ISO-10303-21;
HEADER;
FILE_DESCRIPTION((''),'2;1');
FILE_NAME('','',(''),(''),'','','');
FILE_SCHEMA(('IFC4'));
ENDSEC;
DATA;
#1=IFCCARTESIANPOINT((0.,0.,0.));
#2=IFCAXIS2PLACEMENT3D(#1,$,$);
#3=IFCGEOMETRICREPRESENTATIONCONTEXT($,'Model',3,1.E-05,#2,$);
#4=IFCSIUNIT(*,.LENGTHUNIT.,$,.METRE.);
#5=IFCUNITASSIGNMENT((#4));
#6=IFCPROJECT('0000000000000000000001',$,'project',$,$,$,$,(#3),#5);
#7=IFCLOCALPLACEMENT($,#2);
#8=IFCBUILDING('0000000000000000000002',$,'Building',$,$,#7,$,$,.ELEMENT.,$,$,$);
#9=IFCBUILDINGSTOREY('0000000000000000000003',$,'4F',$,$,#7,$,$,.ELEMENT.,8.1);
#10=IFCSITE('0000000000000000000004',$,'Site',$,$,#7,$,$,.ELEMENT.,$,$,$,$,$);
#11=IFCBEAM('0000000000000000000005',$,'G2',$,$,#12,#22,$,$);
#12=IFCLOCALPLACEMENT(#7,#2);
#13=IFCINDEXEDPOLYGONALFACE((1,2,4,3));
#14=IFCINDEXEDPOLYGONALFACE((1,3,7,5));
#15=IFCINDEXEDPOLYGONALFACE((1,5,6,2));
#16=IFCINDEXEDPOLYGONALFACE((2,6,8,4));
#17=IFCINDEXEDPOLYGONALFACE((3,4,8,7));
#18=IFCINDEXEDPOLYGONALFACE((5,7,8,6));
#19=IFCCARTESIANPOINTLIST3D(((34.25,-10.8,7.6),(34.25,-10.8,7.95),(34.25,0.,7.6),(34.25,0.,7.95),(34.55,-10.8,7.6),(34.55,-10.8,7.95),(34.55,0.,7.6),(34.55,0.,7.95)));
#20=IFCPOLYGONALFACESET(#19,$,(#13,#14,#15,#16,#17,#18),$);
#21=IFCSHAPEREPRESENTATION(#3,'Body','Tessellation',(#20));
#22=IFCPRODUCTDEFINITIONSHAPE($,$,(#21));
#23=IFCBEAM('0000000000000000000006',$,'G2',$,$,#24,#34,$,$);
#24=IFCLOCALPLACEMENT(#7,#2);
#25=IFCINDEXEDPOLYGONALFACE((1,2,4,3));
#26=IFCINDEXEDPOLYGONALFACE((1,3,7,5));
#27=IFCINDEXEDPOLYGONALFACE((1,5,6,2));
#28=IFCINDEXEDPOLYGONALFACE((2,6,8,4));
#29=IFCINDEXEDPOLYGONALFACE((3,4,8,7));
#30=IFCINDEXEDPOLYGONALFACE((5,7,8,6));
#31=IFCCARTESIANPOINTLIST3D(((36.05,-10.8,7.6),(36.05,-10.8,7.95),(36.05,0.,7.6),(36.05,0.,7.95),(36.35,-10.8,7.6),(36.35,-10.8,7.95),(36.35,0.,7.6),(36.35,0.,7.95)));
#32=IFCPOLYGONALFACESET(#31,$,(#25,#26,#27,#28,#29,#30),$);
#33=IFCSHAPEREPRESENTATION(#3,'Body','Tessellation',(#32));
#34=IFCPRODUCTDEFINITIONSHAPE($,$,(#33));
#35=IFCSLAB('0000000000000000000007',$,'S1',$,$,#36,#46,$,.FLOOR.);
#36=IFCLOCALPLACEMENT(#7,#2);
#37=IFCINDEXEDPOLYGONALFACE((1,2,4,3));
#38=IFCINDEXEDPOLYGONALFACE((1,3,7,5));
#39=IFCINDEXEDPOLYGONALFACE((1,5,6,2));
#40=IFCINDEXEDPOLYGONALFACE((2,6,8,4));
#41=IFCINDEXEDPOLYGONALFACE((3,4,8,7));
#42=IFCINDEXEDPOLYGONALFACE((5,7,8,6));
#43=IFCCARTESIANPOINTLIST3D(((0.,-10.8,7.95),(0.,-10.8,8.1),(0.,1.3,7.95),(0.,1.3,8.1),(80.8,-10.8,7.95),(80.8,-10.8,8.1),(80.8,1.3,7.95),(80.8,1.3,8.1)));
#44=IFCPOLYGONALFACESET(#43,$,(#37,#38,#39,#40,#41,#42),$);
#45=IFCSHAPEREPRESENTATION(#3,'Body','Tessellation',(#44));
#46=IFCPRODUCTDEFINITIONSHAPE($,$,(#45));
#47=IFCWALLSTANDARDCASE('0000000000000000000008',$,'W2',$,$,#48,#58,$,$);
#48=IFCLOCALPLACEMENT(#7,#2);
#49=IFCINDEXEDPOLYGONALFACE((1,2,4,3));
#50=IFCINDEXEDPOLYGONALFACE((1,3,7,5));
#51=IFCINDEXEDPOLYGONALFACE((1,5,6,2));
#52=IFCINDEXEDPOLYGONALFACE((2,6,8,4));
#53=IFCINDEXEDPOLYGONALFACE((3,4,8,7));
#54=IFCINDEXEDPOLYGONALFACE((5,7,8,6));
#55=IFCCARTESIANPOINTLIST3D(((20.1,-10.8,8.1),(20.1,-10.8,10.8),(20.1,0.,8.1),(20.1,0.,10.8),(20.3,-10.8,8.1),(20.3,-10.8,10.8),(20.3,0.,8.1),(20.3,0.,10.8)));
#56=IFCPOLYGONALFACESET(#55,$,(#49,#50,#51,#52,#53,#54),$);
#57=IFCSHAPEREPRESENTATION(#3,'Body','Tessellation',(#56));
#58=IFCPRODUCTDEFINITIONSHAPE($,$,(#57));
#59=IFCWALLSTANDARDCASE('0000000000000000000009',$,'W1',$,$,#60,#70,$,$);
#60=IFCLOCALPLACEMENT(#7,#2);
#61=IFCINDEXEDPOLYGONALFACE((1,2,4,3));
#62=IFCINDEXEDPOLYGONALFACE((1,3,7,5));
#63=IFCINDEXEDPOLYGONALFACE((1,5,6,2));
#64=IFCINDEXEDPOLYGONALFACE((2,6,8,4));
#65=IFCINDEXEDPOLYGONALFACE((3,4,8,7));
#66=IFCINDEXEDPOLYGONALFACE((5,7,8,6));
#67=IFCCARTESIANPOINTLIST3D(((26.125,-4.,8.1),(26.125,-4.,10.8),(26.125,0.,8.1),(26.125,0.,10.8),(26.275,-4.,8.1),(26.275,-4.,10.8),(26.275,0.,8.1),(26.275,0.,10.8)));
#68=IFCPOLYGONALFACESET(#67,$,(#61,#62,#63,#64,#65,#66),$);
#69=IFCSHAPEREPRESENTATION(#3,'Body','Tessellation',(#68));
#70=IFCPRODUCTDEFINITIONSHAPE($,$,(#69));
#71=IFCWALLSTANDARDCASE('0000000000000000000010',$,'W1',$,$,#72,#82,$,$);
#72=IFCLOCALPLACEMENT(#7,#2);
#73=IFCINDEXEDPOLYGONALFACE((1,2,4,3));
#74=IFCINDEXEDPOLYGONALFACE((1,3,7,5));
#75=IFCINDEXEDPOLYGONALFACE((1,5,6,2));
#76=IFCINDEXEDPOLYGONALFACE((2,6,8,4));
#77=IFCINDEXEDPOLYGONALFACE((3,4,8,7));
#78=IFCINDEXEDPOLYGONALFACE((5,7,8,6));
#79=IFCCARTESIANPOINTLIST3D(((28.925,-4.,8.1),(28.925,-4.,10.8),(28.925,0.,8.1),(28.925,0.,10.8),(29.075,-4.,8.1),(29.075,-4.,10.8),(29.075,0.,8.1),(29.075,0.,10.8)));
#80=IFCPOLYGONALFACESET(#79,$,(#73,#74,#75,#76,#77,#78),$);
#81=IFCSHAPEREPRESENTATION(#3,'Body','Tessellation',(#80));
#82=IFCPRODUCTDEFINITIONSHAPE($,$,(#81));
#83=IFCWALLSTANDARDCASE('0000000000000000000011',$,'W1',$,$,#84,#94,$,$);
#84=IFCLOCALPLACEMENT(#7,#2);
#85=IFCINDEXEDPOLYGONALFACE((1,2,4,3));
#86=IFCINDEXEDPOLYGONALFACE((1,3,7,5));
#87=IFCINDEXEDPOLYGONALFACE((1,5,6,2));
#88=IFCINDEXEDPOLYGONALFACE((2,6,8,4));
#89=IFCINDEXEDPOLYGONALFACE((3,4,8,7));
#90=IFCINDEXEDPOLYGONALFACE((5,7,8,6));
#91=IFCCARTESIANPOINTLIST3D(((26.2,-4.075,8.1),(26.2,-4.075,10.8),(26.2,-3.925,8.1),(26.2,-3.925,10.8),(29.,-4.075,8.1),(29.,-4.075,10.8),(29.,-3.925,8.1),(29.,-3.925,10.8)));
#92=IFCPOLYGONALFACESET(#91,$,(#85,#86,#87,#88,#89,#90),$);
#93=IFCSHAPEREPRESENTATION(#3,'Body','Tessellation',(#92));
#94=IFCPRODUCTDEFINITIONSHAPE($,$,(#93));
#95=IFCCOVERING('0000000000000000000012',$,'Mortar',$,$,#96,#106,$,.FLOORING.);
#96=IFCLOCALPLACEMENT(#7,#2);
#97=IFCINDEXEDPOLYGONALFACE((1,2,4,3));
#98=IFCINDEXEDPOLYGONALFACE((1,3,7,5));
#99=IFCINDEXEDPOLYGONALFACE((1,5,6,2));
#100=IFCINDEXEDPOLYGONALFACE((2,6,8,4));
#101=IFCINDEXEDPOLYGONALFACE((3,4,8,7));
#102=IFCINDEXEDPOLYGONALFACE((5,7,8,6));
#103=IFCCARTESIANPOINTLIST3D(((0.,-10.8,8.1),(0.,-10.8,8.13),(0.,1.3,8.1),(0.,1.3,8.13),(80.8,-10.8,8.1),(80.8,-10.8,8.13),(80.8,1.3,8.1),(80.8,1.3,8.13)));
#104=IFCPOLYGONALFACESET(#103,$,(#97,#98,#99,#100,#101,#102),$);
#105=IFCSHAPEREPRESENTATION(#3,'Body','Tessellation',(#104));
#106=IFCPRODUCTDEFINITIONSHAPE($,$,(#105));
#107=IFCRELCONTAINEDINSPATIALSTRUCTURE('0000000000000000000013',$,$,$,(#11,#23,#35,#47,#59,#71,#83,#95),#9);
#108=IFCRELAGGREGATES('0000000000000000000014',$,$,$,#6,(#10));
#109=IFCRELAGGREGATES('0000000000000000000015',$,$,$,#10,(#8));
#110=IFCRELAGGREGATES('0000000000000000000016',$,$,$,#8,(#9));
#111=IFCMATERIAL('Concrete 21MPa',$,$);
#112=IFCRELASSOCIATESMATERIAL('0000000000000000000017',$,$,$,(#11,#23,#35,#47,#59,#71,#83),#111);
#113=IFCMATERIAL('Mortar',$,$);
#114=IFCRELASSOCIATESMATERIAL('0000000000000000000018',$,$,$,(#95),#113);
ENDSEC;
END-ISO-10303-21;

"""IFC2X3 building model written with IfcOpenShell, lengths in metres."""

from ifc_helpers import new_model, si_unit, frame, origin, origin_2d, place, context, project, spatial, rectangle, extrude, material, element, save


model = new_model("IFC2X3")

# Units and contexts
model_context = context("Model", 3, precision=1e-05, world=origin())
ifc_project = project(units=[si_unit("LENGTHUNIT", "METRE")], contexts=[model_context])

# Site, building, storey
placement = place(None, origin())
site = spatial("IfcSite", under=ifc_project, at=placement, Name="Site", CompositionType="ELEMENT")
building = spatial("IfcBuilding", under=site, at=placement, Name="Building", CompositionType="ELEMENT")
storey = spatial("IfcBuildingStorey", under=building, at=placement, Name="4F", CompositionType="ELEMENT", Elevation=8.1)

# Shared definitions
ifc_material_1 = material(Name="Concrete 21MPa")

# Beams
for number, where, name in (
    (1, (34.4, -5.4, 7.6), "G2"),
    (2, (36.2, -5.4, 7.6), "G2"),
):
    element("IfcBeam", number, at=place(None, frame(where)), inside=storey, material=ifc_material_1, Name=name, context=model_context, shape_type="SweptSolid", body=[
        extrude(rectangle(XDim=0.3, YDim=10.8, at=origin_2d()), origin(), (0.0, 0.0, 1.0), 0.35),
    ])

# Slab
slab_placement = place(None, frame((40.4, -4.75, 7.95)))
element("IfcSlab", 3, at=slab_placement, inside=storey, material=ifc_material_1, Name="S1", PredefinedType="FLOOR", context=model_context, shape_type="SweptSolid", body=[
    extrude(rectangle(XDim=80.8, YDim=12.1, at=origin_2d()), origin(), (0.0, 0.0, 1.0), 0.15),
])

# Walls
wall_1_placement = place(None, frame((20.2, -5.4, 8.1)))
element("IfcWallStandardCase", 4, at=wall_1_placement, inside=storey, material=ifc_material_1, Name="W2", context=model_context, shape_type="SweptSolid", body=[
    extrude(rectangle(XDim=0.2, YDim=10.8, at=origin_2d()), origin(), (0.0, 0.0, 1.0), 2.7),
])
for number, where, name in (
    (5, (26.2, -2.0, 8.1), "W1"),
    (6, (29.0, -2.0, 8.1), "W1"),
):
    element("IfcWallStandardCase", number, at=place(None, frame(where)), inside=storey, material=ifc_material_1, Name=name, context=model_context, shape_type="SweptSolid", body=[
        extrude(rectangle(XDim=0.15, YDim=4.0, at=origin_2d()), origin(), (0.0, 0.0, 1.0), 2.7),
    ])
wall_2_placement = place(None, frame((27.6, -4.0, 8.1)))
element("IfcWallStandardCase", 7, at=wall_2_placement, inside=storey, material=ifc_material_1, Name="W1", context=model_context, shape_type="SweptSolid", body=[
    extrude(rectangle(XDim=2.8, YDim=0.15, at=origin_2d()), origin(), (0.0, 0.0, 1.0), 2.7),
])

# Covering
ifc_material_2 = material(Name="Mortar")
covering_placement = place(None, frame((40.4, -4.75, 8.1)))
element("IfcCovering", 8, at=covering_placement, inside=storey, material=ifc_material_2, Name="Mortar", PredefinedType="FLOORING", context=model_context, shape_type="SweptSolid", body=[
    extrude(rectangle(XDim=80.8, YDim=12.1, at=origin_2d()), origin(), (0.0, 0.0, 1.0), 0.03),
])

save(model, "model.ifc")
